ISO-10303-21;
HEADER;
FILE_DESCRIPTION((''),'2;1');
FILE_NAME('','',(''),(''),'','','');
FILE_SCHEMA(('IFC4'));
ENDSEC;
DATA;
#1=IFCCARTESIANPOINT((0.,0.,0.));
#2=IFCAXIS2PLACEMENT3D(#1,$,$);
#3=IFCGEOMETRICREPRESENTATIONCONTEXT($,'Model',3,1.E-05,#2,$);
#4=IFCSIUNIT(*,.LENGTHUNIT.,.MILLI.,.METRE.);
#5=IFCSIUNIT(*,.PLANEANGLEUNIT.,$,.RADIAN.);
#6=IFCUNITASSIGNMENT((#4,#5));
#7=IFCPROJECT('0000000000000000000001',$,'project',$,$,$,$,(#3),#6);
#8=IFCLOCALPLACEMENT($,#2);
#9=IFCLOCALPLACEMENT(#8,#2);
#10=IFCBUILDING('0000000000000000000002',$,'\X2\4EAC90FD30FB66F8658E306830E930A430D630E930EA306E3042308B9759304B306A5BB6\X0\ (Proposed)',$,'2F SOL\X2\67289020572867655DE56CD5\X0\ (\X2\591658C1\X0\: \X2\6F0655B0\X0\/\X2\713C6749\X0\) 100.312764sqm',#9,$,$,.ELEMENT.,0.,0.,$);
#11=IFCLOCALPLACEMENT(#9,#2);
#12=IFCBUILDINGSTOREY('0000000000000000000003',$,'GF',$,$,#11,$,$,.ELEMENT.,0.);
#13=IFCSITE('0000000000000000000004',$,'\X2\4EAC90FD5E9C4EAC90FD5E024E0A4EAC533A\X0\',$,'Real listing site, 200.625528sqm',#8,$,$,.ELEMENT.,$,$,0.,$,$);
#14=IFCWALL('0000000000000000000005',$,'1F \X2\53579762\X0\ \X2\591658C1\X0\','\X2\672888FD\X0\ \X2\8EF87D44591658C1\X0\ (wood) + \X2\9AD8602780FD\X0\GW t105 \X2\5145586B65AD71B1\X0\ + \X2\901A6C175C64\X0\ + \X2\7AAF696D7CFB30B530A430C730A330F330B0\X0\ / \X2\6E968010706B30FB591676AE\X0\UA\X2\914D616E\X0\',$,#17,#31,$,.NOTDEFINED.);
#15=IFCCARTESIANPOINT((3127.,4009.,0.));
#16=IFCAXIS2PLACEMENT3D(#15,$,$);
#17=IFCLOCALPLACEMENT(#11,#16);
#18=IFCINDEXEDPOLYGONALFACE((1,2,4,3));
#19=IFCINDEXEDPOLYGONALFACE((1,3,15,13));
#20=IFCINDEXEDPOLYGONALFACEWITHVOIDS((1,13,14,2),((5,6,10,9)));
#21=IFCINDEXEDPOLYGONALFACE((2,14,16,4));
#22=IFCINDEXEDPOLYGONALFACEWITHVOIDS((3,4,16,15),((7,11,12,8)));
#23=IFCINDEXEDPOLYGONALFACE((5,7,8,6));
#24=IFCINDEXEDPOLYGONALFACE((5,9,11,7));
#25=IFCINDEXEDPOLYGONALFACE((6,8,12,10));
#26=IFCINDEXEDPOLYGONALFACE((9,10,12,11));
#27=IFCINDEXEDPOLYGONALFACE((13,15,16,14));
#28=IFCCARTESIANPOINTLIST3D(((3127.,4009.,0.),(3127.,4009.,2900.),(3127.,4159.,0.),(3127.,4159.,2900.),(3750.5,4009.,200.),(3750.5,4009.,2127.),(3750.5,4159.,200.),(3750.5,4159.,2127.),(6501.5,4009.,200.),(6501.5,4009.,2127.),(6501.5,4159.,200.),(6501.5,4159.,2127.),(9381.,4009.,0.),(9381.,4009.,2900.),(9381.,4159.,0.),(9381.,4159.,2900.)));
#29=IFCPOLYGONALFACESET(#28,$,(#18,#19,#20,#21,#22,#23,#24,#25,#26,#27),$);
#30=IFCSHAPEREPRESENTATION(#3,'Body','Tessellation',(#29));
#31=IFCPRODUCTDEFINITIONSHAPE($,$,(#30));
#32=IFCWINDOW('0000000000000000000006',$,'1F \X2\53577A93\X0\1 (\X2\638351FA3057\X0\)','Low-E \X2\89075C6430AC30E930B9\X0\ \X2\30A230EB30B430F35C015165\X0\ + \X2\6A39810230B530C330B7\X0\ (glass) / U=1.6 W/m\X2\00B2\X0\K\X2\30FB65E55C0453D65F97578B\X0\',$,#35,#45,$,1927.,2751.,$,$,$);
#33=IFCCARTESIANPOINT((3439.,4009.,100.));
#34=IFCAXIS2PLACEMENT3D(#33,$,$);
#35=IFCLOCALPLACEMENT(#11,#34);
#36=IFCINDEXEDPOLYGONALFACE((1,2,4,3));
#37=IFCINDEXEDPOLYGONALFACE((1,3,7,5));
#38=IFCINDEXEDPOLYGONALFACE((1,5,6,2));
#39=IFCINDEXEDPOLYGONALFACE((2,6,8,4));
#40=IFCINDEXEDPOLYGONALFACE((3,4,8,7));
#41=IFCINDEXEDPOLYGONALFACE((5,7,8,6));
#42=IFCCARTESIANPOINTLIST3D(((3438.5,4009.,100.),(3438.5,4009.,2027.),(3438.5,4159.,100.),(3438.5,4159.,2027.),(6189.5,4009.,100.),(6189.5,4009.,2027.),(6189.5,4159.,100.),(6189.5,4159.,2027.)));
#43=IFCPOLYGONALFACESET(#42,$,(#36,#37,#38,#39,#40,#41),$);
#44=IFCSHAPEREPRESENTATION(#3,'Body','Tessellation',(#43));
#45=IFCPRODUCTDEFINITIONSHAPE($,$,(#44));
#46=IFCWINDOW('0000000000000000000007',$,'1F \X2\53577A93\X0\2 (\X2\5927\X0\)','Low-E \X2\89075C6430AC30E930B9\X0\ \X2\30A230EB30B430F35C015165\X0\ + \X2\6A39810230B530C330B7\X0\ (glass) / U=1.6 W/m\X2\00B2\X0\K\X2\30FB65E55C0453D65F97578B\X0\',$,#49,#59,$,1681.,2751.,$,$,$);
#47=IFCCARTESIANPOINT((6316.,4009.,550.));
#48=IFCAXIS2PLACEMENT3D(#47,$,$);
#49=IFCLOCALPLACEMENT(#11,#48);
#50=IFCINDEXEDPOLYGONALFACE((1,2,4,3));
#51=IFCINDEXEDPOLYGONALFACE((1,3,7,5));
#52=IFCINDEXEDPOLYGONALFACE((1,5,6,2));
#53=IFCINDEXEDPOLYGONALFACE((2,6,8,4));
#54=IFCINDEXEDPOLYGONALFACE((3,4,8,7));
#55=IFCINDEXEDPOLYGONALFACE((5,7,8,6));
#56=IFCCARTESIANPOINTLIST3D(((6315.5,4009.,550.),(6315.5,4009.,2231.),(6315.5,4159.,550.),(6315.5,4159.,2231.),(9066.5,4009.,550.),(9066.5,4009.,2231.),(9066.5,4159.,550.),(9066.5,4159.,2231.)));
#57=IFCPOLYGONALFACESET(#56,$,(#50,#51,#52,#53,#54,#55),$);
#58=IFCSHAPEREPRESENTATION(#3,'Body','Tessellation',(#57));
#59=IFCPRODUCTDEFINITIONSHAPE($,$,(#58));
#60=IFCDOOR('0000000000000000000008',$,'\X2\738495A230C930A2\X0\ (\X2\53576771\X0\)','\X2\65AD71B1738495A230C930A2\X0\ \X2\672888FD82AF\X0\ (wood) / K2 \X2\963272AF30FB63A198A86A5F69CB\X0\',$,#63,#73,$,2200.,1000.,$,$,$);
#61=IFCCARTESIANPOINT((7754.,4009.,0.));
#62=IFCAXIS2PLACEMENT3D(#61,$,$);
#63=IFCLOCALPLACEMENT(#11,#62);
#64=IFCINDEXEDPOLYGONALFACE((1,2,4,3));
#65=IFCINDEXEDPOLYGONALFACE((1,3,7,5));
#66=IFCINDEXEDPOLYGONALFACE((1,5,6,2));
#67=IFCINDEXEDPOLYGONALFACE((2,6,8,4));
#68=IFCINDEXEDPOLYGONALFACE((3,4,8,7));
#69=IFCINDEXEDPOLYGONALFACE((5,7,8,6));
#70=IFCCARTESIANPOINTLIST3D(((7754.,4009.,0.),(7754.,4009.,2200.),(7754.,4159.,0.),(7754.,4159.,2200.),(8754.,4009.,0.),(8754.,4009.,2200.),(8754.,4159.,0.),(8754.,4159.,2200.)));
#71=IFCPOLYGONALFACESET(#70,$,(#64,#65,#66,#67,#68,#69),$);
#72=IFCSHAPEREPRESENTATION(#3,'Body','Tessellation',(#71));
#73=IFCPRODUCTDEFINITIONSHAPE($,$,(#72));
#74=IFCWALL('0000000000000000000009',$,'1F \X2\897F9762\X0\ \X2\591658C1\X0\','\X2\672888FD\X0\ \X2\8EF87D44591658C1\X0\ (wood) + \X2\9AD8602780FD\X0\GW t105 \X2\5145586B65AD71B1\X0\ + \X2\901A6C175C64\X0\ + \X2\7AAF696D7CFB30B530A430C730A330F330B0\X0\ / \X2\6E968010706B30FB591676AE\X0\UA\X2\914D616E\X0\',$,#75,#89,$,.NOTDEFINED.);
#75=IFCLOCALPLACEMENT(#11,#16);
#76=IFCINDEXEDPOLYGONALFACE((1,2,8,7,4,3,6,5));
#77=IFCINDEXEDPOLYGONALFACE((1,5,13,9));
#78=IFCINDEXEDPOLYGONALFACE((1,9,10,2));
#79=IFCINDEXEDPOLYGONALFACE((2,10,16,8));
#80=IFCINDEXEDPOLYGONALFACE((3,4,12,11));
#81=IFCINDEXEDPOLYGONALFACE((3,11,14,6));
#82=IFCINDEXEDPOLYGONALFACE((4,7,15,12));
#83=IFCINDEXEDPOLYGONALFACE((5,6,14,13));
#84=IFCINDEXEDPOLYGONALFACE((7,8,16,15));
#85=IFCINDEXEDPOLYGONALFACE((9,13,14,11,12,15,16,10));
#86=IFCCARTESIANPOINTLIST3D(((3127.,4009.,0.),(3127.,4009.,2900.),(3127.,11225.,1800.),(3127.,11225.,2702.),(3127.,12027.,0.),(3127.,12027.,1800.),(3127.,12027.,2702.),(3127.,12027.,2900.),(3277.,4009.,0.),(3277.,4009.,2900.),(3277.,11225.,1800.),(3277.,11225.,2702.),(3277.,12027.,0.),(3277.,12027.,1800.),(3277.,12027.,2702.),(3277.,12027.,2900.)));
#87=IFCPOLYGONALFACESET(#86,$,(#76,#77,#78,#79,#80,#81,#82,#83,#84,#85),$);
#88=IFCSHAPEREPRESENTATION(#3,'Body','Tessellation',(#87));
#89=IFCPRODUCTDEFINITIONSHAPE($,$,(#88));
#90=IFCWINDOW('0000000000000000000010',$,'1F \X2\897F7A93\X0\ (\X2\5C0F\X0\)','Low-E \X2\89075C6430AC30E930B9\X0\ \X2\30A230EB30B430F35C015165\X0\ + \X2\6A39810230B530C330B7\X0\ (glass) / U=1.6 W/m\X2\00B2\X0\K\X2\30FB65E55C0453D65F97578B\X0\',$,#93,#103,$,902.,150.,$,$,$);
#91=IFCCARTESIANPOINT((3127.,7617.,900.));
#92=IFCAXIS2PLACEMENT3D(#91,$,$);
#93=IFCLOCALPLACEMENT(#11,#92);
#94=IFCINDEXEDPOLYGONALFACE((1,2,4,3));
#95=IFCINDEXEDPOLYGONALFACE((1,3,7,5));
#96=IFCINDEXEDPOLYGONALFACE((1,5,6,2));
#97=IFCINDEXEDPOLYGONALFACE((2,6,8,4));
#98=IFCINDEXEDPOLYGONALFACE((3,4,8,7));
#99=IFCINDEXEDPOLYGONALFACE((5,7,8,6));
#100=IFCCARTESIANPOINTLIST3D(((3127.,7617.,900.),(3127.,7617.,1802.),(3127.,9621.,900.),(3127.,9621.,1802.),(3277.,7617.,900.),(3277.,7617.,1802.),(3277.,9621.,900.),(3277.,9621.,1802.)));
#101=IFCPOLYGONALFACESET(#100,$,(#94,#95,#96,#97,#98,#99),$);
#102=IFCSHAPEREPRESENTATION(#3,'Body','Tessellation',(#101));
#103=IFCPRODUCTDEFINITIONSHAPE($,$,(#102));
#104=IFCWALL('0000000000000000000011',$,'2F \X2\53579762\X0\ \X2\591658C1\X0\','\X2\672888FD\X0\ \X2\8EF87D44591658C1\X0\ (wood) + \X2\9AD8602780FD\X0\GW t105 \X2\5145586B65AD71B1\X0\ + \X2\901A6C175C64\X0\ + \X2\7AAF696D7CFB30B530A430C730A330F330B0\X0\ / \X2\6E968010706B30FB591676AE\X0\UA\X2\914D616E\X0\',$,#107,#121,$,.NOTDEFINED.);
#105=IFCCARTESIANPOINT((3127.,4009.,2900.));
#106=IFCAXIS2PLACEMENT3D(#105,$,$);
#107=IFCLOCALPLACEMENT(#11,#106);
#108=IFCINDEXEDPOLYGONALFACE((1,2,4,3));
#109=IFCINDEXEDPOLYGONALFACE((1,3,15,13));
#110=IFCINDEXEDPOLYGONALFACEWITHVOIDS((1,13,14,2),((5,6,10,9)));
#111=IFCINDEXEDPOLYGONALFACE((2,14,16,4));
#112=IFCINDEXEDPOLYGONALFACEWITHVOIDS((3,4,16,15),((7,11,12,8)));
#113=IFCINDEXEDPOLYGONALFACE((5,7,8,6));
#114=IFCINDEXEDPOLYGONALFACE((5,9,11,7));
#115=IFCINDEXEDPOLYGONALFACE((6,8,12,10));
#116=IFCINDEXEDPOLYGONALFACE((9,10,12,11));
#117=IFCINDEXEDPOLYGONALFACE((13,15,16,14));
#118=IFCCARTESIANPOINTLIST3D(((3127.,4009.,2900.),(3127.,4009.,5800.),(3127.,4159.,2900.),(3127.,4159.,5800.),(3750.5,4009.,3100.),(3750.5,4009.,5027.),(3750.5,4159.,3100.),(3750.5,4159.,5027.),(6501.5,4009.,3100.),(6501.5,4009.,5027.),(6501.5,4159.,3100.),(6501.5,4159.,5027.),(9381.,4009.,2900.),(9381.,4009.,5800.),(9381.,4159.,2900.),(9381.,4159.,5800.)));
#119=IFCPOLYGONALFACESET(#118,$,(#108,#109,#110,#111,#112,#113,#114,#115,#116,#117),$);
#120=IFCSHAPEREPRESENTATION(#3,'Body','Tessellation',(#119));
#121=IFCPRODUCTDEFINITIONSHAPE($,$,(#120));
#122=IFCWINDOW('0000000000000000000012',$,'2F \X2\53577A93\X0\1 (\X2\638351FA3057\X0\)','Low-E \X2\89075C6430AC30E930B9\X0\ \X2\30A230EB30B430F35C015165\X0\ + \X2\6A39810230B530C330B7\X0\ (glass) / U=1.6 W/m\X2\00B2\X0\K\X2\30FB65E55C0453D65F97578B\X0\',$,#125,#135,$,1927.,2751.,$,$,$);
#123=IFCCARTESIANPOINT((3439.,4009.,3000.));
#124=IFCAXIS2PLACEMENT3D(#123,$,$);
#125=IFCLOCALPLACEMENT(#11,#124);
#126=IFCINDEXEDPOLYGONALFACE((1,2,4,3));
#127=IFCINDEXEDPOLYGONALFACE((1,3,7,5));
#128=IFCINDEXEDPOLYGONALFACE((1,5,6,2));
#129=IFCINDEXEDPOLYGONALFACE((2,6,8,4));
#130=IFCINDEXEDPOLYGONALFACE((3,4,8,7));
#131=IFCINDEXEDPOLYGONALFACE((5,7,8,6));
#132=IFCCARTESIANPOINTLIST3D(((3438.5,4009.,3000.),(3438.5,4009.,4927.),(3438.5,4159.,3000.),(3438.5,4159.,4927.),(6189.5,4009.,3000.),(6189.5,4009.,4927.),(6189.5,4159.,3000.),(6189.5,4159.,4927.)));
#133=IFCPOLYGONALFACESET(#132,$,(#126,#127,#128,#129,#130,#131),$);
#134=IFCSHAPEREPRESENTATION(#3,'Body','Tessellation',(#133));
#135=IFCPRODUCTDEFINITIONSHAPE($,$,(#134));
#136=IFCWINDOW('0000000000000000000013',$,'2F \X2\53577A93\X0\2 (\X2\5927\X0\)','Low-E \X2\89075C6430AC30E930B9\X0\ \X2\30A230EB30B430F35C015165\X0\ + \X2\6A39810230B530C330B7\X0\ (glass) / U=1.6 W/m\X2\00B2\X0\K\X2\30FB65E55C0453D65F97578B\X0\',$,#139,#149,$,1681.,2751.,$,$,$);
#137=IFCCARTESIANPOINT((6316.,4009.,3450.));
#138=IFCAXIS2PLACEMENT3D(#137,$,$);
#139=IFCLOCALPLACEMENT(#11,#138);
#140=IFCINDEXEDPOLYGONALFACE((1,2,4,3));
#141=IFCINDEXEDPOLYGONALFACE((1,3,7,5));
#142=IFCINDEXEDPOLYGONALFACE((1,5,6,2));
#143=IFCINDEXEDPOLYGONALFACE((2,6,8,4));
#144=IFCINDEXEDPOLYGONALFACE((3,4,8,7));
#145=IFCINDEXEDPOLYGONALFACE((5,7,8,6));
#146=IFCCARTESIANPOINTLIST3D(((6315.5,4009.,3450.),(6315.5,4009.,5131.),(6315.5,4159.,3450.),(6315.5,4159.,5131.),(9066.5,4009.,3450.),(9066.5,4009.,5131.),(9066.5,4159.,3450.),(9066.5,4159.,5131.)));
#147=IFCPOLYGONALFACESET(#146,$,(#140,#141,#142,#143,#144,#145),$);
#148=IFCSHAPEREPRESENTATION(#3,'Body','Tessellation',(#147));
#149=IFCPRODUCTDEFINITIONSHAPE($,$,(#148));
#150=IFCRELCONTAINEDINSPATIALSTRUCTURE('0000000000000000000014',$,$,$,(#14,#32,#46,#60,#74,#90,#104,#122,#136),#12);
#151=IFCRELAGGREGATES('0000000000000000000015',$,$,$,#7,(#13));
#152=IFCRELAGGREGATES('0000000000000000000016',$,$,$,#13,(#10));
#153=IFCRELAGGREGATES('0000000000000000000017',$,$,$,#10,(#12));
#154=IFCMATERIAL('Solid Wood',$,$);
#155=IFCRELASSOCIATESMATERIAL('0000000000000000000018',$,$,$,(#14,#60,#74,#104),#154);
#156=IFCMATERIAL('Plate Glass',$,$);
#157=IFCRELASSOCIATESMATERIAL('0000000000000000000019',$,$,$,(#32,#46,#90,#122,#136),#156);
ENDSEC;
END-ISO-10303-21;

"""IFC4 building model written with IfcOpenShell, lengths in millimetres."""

from ifc_helpers import new_model, si_unit, frame, frame_2d, origin, place, context, project, spatial, rectangle, extrude, material, element, fill, save


model = new_model("IFC4")

# Units and contexts
model_context = context("Model", 3, precision=1e-05, world=origin())
ifc_project = project(units=[si_unit("LENGTHUNIT", "METRE", prefix="MILLI"), si_unit("PLANEANGLEUNIT", "RADIAN")], contexts=[model_context])

# Site, building, storey
site_placement = place(None, origin())
site = spatial("IfcSite", under=ifc_project, at=site_placement, Name="京都府京都市上京区", ObjectType="Real listing site, 200.625528sqm", CompositionType="ELEMENT", RefElevation=0.0)
building_placement = place(site_placement, origin())
building = spatial("IfcBuilding", under=site, at=building_placement, Name="京都・書斎とライブラリのある静かな家 (Proposed)", ObjectType="2F SOL木造在来工法 (外壁: 漆喰/焼杉) 100.312764sqm", CompositionType="ELEMENT", ElevationOfRefHeight=0.0, ElevationOfTerrain=0.0)
storey_placement = place(building_placement, origin())
storey = spatial("IfcBuildingStorey", under=building, at=storey_placement, Name="GF", CompositionType="ELEMENT", Elevation=0.0)

# Shared definitions
ifc_material_1 = material(Name="Solid Wood")

# Wall, openings, windows, door
wall_1_placement = place(storey_placement, frame((3127.0, 4009.0, 0.0)))
wall_1 = element("IfcWall", 1, at=wall_1_placement, inside=storey, material=ifc_material_1, Name="1F 南面 外壁", Description="木製 軸組外壁 (wood) + 高性能GW t105 充填断熱 + 通気層 + 窯業系サイディング / 準耐火・外皮UA配慮", PredefinedType="NOTDEFINED", context=model_context, shape_type="SweptSolid", body=[
    extrude(rectangle(XDim=6254.0, YDim=150.0, at=frame_2d((3127.0, 75.0))), frame((3127.0, 4009.0, 0.0)), (0.0, 0.0, 1.0), 2900.0),
])
opening_1_placement = place(storey_placement, frame((3439.0, 4009.0, 100.0)))
opening_1 = element("IfcOpeningElement", 2, at=opening_1_placement, cuts=wall_1, PredefinedType="NOTDEFINED", context=model_context, shape_type="SweptSolid", body=[
    extrude(rectangle(XDim=2751.0, YDim=150.0, at=frame_2d((1375.0, 75.0))), frame((3439.0, 4009.0, 100.0)), (0.0, 0.0, 1.0), 1927.0),
])
opening_2_placement = place(storey_placement, frame((6316.0, 4009.0, 550.0)))
opening_2 = element("IfcOpeningElement", 3, at=opening_2_placement, cuts=wall_1, PredefinedType="NOTDEFINED", context=model_context, shape_type="SweptSolid", body=[
    extrude(rectangle(XDim=2751.0, YDim=150.0, at=frame_2d((1375.0, 75.0))), frame((6316.0, 4009.0, 550.0)), (0.0, 0.0, 1.0), 1681.0),
])
opening_3_placement = place(storey_placement, frame((7754.0, 4009.0, 0.0)))
opening_3 = element("IfcOpeningElement", 4, at=opening_3_placement, cuts=wall_1, PredefinedType="NOTDEFINED", context=model_context, shape_type="SweptSolid", body=[
    extrude(rectangle(XDim=1000.0, YDim=150.0, at=frame_2d((500.0, 75.0))), frame((7754.0, 4009.0, 0.0)), (0.0, 0.0, 1.0), 2200.0),
])
ifc_material_2 = material(Name="Plate Glass")
window_1_placement = place(storey_placement, frame((3439.0, 4009.0, 100.0)))
window_1 = element("IfcWindow", 5, at=window_1_placement, inside=storey, material=ifc_material_2, Name="1F 南窓1 (掃出し)", Description="Low-E 複層ガラス アルゴン封入 + 樹脂サッシ (glass) / U=1.6 W/m²K・日射取得型", OverallHeight=1927.0, OverallWidth=2751.0, context=model_context, shape_type="SweptSolid", body=[
    extrude(rectangle(XDim=2751.0, YDim=150.0, at=frame_2d((1375.0, 75.0))), frame((3439.0, 4009.0, 100.0)), (0.0, 0.0, 1.0), 1927.0),
])
fill(opening_1, window_1)
window_2_placement = place(storey_placement, frame((6316.0, 4009.0, 550.0)))
window_2 = element("IfcWindow", 6, at=window_2_placement, inside=storey, material=ifc_material_2, Name="1F 南窓2 (大)", Description="Low-E 複層ガラス アルゴン封入 + 樹脂サッシ (glass) / U=1.6 W/m²K・日射取得型", OverallHeight=1681.0, OverallWidth=2751.0, context=model_context, shape_type="SweptSolid", body=[
    extrude(rectangle(XDim=2751.0, YDim=150.0, at=frame_2d((1375.0, 75.0))), frame((6316.0, 4009.0, 550.0)), (0.0, 0.0, 1.0), 1681.0),
])
fill(opening_2, window_2)
door_placement = place(storey_placement, frame((7754.0, 4009.0, 0.0)))
door = element("IfcDoor", 7, at=door_placement, inside=storey, material=ifc_material_1, Name="玄関ドア (南東)", Description="断熱玄関ドア 木製芯 (wood) / K2 防犯・採風機構", OverallHeight=2200.0, OverallWidth=1000.0, context=model_context, shape_type="SweptSolid", body=[
    extrude(rectangle(XDim=1000.0, YDim=150.0, at=frame_2d((500.0, 75.0))), frame((7754.0, 4009.0, 0.0)), (0.0, 0.0, 1.0), 2200.0),
])
fill(opening_3, door)

# Wall, opening, window
wall_2_placement = place(storey_placement, frame((3127.0, 4009.0, 0.0)))
wall_2 = element("IfcWall", 8, at=wall_2_placement, inside=storey, material=ifc_material_1, Name="1F 西面 外壁", Description="木製 軸組外壁 (wood) + 高性能GW t105 充填断熱 + 通気層 + 窯業系サイディング / 準耐火・外皮UA配慮", PredefinedType="NOTDEFINED", context=model_context, shape_type="SweptSolid", body=[
    extrude(rectangle(XDim=150.0, YDim=8018.0, at=frame_2d((75.0, 4009.0))), frame((3127.0, 4009.0, 0.0)), (0.0, 0.0, 1.0), 2900.0),
])
opening_4_placement = place(storey_placement, frame((3127.0, 7617.0, 900.0)))
opening_4 = element("IfcOpeningElement", 9, at=opening_4_placement, cuts=wall_2, PredefinedType="NOTDEFINED", context=model_context, shape_type="SweptSolid", body=[
    extrude(rectangle(XDim=150.0, YDim=2004.0, at=frame_2d((75.0, 1002.0))), frame((3127.0, 7617.0, 900.0)), (0.0, 0.0, 1.0), 902.0),
])
window_3_placement = place(storey_placement, frame((3127.0, 7617.0, 900.0)))
window_3 = element("IfcWindow", 10, at=window_3_placement, inside=storey, material=ifc_material_2, Name="1F 西窓 (小)", Description="Low-E 複層ガラス アルゴン封入 + 樹脂サッシ (glass) / U=1.6 W/m²K・日射取得型", OverallHeight=902.0, OverallWidth=150.0, context=model_context, shape_type="SweptSolid", body=[
    extrude(rectangle(XDim=150.0, YDim=2004.0, at=frame_2d((75.0, 1002.0))), frame((3127.0, 7617.0, 900.0)), (0.0, 0.0, 1.0), 902.0),
])
fill(opening_4, window_3)

# Wall, openings, windows
wall_3_placement = place(storey_placement, frame((3127.0, 4009.0, 2900.0)))
wall_3 = element("IfcWall", 11, at=wall_3_placement, inside=storey, material=ifc_material_1, Name="2F 南面 外壁", Description="木製 軸組外壁 (wood) + 高性能GW t105 充填断熱 + 通気層 + 窯業系サイディング / 準耐火・外皮UA配慮", PredefinedType="NOTDEFINED", context=model_context, shape_type="SweptSolid", body=[
    extrude(rectangle(XDim=6254.0, YDim=150.0, at=frame_2d((3127.0, 75.0))), frame((3127.0, 4009.0, 2900.0)), (0.0, 0.0, 1.0), 2900.0),
])
opening_5_placement = place(storey_placement, frame((3439.0, 4009.0, 3000.0)))
opening_5 = element("IfcOpeningElement", 12, at=opening_5_placement, cuts=wall_3, PredefinedType="NOTDEFINED", context=model_context, shape_type="SweptSolid", body=[
    extrude(rectangle(XDim=2751.0, YDim=150.0, at=frame_2d((1375.0, 75.0))), frame((3439.0, 4009.0, 3000.0)), (0.0, 0.0, 1.0), 1927.0),
])
opening_6_placement = place(storey_placement, frame((6316.0, 4009.0, 3450.0)))
opening_6 = element("IfcOpeningElement", 13, at=opening_6_placement, cuts=wall_3, PredefinedType="NOTDEFINED", context=model_context, shape_type="SweptSolid", body=[
    extrude(rectangle(XDim=2751.0, YDim=150.0, at=frame_2d((1375.0, 75.0))), frame((6316.0, 4009.0, 3450.0)), (0.0, 0.0, 1.0), 1681.0),
])
window_4_placement = place(storey_placement, frame((3439.0, 4009.0, 3000.0)))
window_4 = element("IfcWindow", 14, at=window_4_placement, inside=storey, material=ifc_material_2, Name="2F 南窓1 (掃出し)", Description="Low-E 複層ガラス アルゴン封入 + 樹脂サッシ (glass) / U=1.6 W/m²K・日射取得型", OverallHeight=1927.0, OverallWidth=2751.0, context=model_context, shape_type="SweptSolid", body=[
    extrude(rectangle(XDim=2751.0, YDim=150.0, at=frame_2d((1375.0, 75.0))), frame((3439.0, 4009.0, 3000.0)), (0.0, 0.0, 1.0), 1927.0),
])
fill(opening_5, window_4)
window_5_placement = place(storey_placement, frame((6316.0, 4009.0, 3450.0)))
window_5 = element("IfcWindow", 15, at=window_5_placement, inside=storey, material=ifc_material_2, Name="2F 南窓2 (大)", Description="Low-E 複層ガラス アルゴン封入 + 樹脂サッシ (glass) / U=1.6 W/m²K・日射取得型", OverallHeight=1681.0, OverallWidth=2751.0, context=model_context, shape_type="SweptSolid", body=[
    extrude(rectangle(XDim=2751.0, YDim=150.0, at=frame_2d((1375.0, 75.0))), frame((6316.0, 4009.0, 3450.0)), (0.0, 0.0, 1.0), 1681.0),
])
fill(opening_6, window_5)

save(model, "model.ifc")
